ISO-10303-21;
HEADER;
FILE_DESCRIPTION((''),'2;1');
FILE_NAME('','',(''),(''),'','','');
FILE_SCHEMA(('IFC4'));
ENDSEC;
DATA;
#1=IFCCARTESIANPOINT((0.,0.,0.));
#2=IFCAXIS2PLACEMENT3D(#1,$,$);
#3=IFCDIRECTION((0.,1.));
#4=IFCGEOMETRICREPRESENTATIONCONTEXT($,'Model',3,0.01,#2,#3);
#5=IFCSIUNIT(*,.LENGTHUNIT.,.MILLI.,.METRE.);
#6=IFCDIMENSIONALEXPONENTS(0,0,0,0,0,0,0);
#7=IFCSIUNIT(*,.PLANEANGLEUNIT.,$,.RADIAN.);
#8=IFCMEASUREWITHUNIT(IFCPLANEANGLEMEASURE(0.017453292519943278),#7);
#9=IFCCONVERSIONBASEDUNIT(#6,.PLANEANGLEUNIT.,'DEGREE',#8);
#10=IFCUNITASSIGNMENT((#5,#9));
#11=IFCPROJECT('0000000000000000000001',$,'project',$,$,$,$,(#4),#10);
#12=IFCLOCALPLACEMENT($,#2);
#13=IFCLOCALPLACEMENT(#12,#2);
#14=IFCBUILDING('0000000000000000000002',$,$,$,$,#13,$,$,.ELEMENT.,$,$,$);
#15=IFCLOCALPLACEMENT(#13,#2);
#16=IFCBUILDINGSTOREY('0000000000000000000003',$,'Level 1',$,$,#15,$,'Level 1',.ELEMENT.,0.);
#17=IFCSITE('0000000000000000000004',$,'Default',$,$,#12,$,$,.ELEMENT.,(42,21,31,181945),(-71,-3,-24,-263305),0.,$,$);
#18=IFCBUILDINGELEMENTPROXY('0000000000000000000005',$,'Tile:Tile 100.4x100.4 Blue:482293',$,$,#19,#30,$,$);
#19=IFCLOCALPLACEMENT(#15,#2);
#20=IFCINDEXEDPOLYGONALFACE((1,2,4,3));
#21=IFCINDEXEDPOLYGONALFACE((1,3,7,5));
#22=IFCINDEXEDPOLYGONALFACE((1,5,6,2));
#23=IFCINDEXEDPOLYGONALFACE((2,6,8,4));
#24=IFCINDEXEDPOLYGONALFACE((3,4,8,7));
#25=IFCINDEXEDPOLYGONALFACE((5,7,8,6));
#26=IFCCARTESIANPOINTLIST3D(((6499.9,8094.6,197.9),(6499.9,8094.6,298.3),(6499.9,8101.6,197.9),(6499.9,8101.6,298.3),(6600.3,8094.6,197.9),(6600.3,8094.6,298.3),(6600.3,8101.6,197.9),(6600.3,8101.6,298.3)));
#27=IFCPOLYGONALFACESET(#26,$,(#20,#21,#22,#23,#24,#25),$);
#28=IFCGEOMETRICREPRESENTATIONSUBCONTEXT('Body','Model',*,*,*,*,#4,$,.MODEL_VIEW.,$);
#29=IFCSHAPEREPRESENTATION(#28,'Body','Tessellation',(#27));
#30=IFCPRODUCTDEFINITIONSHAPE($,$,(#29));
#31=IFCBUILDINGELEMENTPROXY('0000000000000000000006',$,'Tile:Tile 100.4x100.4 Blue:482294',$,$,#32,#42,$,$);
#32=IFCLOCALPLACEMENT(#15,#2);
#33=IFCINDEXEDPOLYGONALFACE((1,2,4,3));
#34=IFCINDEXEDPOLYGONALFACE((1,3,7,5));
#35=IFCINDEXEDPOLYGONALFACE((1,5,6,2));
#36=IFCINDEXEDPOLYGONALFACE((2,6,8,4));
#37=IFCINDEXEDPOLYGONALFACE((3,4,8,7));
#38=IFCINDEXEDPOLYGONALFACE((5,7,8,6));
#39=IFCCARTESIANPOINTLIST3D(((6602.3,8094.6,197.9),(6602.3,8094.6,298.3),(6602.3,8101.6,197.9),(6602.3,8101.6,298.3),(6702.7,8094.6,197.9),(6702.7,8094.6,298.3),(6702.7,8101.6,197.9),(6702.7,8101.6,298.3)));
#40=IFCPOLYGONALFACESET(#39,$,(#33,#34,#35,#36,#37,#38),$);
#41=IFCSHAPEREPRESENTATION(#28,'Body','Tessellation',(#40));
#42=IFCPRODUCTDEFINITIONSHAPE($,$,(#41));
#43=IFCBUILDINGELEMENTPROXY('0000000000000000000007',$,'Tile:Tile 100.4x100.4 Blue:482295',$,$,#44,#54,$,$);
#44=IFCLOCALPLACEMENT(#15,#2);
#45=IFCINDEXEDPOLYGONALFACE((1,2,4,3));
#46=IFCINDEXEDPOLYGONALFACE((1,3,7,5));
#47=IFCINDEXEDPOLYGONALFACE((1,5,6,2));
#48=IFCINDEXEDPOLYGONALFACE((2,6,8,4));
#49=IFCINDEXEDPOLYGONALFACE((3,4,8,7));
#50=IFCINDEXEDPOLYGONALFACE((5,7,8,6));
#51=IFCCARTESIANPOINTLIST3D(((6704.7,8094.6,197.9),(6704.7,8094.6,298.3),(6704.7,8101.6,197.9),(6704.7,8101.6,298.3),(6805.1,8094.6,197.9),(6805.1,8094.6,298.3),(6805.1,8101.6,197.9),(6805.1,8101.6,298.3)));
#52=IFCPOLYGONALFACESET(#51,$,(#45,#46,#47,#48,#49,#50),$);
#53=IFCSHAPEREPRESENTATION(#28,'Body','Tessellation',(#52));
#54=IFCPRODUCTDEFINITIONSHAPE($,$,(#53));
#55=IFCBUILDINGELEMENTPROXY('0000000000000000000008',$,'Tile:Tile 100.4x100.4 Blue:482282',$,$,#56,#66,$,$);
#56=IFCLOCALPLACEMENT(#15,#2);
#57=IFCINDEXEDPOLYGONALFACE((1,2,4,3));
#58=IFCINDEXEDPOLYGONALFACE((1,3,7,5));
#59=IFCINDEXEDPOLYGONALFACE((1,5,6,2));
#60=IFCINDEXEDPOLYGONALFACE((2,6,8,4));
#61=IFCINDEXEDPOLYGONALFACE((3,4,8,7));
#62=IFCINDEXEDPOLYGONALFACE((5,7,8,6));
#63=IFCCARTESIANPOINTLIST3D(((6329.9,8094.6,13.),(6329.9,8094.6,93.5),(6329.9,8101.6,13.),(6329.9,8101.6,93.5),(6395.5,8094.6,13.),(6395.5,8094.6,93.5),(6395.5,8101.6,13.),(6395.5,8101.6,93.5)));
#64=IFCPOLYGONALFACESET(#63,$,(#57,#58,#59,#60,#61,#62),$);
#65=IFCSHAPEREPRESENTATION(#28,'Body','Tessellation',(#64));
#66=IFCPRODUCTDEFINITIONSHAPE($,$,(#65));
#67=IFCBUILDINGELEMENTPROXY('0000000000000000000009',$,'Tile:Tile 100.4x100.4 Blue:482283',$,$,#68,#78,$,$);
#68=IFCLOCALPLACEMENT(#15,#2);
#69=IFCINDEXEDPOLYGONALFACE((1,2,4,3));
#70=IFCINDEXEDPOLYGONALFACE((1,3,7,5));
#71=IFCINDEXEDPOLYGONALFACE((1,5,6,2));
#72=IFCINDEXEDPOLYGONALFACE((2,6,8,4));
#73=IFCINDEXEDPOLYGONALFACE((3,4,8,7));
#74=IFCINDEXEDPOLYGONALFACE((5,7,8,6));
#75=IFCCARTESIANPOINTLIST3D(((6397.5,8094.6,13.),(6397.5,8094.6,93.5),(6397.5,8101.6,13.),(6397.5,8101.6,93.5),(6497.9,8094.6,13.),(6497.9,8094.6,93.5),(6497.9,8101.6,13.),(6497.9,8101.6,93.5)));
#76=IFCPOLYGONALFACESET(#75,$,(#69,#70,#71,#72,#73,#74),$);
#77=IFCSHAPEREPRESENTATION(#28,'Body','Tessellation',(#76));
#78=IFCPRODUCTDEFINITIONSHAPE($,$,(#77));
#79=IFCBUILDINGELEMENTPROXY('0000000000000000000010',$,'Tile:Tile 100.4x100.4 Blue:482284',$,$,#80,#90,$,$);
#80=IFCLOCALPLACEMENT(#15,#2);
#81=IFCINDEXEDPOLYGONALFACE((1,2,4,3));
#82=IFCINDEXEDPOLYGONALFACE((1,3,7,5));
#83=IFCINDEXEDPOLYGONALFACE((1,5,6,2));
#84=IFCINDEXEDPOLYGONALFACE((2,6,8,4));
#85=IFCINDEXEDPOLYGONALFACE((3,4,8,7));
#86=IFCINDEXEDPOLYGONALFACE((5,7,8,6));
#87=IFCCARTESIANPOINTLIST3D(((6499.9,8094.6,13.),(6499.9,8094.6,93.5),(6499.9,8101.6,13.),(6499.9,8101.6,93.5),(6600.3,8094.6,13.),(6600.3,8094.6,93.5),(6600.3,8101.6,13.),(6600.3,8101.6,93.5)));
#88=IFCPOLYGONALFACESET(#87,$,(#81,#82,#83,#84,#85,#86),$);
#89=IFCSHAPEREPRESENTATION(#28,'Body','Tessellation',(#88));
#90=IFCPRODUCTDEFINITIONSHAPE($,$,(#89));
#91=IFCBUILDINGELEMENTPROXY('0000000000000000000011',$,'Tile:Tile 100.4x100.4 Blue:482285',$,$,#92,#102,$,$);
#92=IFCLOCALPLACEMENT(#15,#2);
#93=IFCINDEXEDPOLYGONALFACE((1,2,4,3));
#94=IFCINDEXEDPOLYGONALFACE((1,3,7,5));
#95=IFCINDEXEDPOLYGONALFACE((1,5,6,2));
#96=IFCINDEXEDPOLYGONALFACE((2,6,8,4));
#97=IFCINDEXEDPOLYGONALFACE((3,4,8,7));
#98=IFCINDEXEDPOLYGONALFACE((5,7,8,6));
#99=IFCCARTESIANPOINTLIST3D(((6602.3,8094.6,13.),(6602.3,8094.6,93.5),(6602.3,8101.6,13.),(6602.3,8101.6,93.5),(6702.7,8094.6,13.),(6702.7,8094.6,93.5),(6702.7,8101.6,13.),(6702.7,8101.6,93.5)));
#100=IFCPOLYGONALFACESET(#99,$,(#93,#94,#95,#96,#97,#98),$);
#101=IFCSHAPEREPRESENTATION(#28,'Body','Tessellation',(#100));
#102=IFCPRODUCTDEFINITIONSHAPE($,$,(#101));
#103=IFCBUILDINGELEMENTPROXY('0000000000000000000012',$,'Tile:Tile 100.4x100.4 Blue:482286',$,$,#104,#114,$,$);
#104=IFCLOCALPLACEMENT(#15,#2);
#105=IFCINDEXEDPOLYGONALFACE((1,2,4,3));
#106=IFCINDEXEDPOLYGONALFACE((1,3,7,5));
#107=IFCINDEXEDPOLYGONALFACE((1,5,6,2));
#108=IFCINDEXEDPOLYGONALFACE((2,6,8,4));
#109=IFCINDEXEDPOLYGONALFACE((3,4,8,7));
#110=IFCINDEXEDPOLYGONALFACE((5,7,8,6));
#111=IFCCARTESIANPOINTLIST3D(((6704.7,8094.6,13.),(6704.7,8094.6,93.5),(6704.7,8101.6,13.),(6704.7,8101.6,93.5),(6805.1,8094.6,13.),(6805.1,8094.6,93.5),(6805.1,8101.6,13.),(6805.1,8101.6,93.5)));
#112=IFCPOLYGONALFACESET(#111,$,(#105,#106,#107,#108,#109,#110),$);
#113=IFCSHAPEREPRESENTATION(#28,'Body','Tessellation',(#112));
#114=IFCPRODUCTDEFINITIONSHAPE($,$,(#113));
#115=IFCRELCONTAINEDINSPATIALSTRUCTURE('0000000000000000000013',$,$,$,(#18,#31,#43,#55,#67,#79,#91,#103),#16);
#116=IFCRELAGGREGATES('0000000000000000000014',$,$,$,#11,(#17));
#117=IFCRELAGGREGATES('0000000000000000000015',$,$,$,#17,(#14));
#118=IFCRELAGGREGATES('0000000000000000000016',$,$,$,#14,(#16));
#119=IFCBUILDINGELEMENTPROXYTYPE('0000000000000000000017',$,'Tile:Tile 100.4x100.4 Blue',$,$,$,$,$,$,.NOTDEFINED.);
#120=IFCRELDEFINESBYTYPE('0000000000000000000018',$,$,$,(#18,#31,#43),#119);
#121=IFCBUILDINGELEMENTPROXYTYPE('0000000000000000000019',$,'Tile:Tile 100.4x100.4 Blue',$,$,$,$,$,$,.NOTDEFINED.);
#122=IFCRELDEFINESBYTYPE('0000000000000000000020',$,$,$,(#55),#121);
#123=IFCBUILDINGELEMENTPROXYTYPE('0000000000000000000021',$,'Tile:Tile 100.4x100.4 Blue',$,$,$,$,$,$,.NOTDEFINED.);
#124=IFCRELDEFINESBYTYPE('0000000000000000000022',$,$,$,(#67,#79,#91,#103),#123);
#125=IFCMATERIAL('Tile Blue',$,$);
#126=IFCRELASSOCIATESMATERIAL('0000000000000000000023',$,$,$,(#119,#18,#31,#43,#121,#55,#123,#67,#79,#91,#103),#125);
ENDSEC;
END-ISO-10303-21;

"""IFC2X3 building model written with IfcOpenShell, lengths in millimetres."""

from ifc_helpers import new_model, entity, si_unit, converted_unit, direction, frame, frame_2d, origin, origin_2d_with_axis, place, context, subcontext, project, spatial, rectangle, extrude, source, transform, mapped, material, type_object, type_shapes, element, save


model = new_model("IFC2X3")

# Units and contexts
model_context = context("Model", 3, precision=0.01, world=origin(), true_north=direction((0.0, 1.0)))
body_context = subcontext(model_context, "Body", "Model", "MODEL_VIEW")
ifc_project = project(units=[si_unit("LENGTHUNIT", "METRE", prefix="MILLI"), converted_unit("PLANEANGLEUNIT", "DEGREE", entity("IfcPlaneAngleMeasure", 0.017453292519943278), si_unit("PLANEANGLEUNIT", "RADIAN"), dimensions=[0, 0, 0, 0, 0, 0, 0])], contexts=[model_context])

# Site, building, storey
site_placement = place(None, origin())
site = spatial("IfcSite", under=ifc_project, at=site_placement, Name="Default", CompositionType="ELEMENT", RefLatitude=(42, 21, 31, 181945), RefLongitude=(-71, -3, -24, -263305), RefElevation=0.0)
building_placement = place(site_placement, origin())
building = spatial("IfcBuilding", under=site, at=building_placement, CompositionType="ELEMENT")
storey_placement = place(building_placement, origin())
storey = spatial("IfcBuildingStorey", under=building, at=storey_placement, Name="Level 1", LongName="Level 1", CompositionType="ELEMENT", Elevation=0.0)

# Building element proxies
ifc_material_1 = material(Name="Tile Blue")
building_element_proxy_type_1 = type_object("IfcBuildingElementProxyType", Name="Tile:Tile 100.4x100.4 Blue", PredefinedType="NOTDEFINED", material=ifc_material_1)
shared_shape_1 = source(origin(), body_context, "Body", "SweptSolid", [
    extrude(rectangle(XDim=100.4, YDim=100.4, at=origin_2d_with_axis()), frame((-50.2, -50.2, 0.0), z_axis=(0.0, 0.0, 1.0), x_axis=(0.0, -1.0, 0.0)), (0.0, 0.0, 1.0), 7.0),
])
type_shapes(building_element_proxy_type_1, [shared_shape_1])
for number, where, z_axis, x_axis, name in (
    (1, (6499.9, 8101.6, 197.9), (0.0, -1.0, 0.0), (-1.0, 0.0, 0.0), "Tile:Tile 100.4x100.4 Blue:482293"),
    (2, (6602.3, 8101.6, 197.9), (0.0, -1.0, 0.0), (-1.0, 0.0, 0.0), "Tile:Tile 100.4x100.4 Blue:482294"),
    (3, (6704.7, 8101.6, 197.9), (0.0, -1.0, 0.0), (-1.0, 0.0, 0.0), "Tile:Tile 100.4x100.4 Blue:482295"),
):
    element("IfcBuildingElementProxy", number, at=place(storey_placement, frame(where, z_axis=z_axis, x_axis=x_axis)), inside=storey, type_object=building_element_proxy_type_1, material=ifc_material_1, Name=name, context=body_context, shape_type="MappedRepresentation", body=[
        mapped(shared_shape_1, transform((0.0, 0.0, 0.0), scale=1.0)),
    ])
building_element_proxy_type_2 = type_object("IfcBuildingElementProxyType", Name="Tile:Tile 100.4x100.4 Blue", PredefinedType="NOTDEFINED", material=ifc_material_1)
shared_shape_2 = source(origin(), body_context, "Body", "SweptSolid", [
    extrude(rectangle(XDim=65.6, YDim=80.5, at=frame_2d((0.0, 0.0), x_axis=(1.0, 0.0))), frame((-32.8, -40.3, 0.0), z_axis=(0.0, 0.0, 1.0), x_axis=(-1.0, 0.0, 0.0)), (0.0, 0.0, 1.0), 7.0),
])
type_shapes(building_element_proxy_type_2, [shared_shape_2])
proxy_placement = place(storey_placement, frame((6329.9, 8101.6, 13.0), z_axis=(0.0, -1.0, 0.0), x_axis=(-1.0, 0.0, 0.0)))
element("IfcBuildingElementProxy", 4, at=proxy_placement, inside=storey, type_object=building_element_proxy_type_2, material=ifc_material_1, Name="Tile:Tile 100.4x100.4 Blue:482282", context=body_context, shape_type="MappedRepresentation", body=[
    mapped(shared_shape_2, transform((0.0, 0.0, 0.0), scale=1.0)),
])
building_element_proxy_type_3 = type_object("IfcBuildingElementProxyType", Name="Tile:Tile 100.4x100.4 Blue", PredefinedType="NOTDEFINED", material=ifc_material_1)
shared_shape_3 = source(origin(), body_context, "Body", "SweptSolid", [
    extrude(rectangle(XDim=80.5, YDim=100.4, at=origin_2d_with_axis()), frame((-50.2, -40.3, 0.0), z_axis=(0.0, 0.0, 1.0), x_axis=(0.0, -1.0, 0.0)), (0.0, 0.0, 1.0), 7.0),
])
type_shapes(building_element_proxy_type_3, [shared_shape_3])
for number, where, z_axis, x_axis, name in (
    (5, (6397.5, 8101.6, 13.0), (0.0, -1.0, 0.0), (-1.0, 0.0, 0.0), "Tile:Tile 100.4x100.4 Blue:482283"),
    (6, (6499.9, 8101.6, 13.0), (0.0, -1.0, 0.0), (-1.0, 0.0, 0.0), "Tile:Tile 100.4x100.4 Blue:482284"),
    (7, (6602.3, 8101.6, 13.0), (0.0, -1.0, 0.0), (-1.0, 0.0, 0.0), "Tile:Tile 100.4x100.4 Blue:482285"),
    (8, (6704.7, 8101.6, 13.0), (0.0, -1.0, 0.0), (-1.0, 0.0, 0.0), "Tile:Tile 100.4x100.4 Blue:482286"),
):
    element("IfcBuildingElementProxy", number, at=place(storey_placement, frame(where, z_axis=z_axis, x_axis=x_axis)), inside=storey, type_object=building_element_proxy_type_3, material=ifc_material_1, Name=name, context=body_context, shape_type="MappedRepresentation", body=[
        mapped(shared_shape_3, transform((0.0, 0.0, 0.0), scale=1.0)),
    ])

save(model, "model.ifc")
